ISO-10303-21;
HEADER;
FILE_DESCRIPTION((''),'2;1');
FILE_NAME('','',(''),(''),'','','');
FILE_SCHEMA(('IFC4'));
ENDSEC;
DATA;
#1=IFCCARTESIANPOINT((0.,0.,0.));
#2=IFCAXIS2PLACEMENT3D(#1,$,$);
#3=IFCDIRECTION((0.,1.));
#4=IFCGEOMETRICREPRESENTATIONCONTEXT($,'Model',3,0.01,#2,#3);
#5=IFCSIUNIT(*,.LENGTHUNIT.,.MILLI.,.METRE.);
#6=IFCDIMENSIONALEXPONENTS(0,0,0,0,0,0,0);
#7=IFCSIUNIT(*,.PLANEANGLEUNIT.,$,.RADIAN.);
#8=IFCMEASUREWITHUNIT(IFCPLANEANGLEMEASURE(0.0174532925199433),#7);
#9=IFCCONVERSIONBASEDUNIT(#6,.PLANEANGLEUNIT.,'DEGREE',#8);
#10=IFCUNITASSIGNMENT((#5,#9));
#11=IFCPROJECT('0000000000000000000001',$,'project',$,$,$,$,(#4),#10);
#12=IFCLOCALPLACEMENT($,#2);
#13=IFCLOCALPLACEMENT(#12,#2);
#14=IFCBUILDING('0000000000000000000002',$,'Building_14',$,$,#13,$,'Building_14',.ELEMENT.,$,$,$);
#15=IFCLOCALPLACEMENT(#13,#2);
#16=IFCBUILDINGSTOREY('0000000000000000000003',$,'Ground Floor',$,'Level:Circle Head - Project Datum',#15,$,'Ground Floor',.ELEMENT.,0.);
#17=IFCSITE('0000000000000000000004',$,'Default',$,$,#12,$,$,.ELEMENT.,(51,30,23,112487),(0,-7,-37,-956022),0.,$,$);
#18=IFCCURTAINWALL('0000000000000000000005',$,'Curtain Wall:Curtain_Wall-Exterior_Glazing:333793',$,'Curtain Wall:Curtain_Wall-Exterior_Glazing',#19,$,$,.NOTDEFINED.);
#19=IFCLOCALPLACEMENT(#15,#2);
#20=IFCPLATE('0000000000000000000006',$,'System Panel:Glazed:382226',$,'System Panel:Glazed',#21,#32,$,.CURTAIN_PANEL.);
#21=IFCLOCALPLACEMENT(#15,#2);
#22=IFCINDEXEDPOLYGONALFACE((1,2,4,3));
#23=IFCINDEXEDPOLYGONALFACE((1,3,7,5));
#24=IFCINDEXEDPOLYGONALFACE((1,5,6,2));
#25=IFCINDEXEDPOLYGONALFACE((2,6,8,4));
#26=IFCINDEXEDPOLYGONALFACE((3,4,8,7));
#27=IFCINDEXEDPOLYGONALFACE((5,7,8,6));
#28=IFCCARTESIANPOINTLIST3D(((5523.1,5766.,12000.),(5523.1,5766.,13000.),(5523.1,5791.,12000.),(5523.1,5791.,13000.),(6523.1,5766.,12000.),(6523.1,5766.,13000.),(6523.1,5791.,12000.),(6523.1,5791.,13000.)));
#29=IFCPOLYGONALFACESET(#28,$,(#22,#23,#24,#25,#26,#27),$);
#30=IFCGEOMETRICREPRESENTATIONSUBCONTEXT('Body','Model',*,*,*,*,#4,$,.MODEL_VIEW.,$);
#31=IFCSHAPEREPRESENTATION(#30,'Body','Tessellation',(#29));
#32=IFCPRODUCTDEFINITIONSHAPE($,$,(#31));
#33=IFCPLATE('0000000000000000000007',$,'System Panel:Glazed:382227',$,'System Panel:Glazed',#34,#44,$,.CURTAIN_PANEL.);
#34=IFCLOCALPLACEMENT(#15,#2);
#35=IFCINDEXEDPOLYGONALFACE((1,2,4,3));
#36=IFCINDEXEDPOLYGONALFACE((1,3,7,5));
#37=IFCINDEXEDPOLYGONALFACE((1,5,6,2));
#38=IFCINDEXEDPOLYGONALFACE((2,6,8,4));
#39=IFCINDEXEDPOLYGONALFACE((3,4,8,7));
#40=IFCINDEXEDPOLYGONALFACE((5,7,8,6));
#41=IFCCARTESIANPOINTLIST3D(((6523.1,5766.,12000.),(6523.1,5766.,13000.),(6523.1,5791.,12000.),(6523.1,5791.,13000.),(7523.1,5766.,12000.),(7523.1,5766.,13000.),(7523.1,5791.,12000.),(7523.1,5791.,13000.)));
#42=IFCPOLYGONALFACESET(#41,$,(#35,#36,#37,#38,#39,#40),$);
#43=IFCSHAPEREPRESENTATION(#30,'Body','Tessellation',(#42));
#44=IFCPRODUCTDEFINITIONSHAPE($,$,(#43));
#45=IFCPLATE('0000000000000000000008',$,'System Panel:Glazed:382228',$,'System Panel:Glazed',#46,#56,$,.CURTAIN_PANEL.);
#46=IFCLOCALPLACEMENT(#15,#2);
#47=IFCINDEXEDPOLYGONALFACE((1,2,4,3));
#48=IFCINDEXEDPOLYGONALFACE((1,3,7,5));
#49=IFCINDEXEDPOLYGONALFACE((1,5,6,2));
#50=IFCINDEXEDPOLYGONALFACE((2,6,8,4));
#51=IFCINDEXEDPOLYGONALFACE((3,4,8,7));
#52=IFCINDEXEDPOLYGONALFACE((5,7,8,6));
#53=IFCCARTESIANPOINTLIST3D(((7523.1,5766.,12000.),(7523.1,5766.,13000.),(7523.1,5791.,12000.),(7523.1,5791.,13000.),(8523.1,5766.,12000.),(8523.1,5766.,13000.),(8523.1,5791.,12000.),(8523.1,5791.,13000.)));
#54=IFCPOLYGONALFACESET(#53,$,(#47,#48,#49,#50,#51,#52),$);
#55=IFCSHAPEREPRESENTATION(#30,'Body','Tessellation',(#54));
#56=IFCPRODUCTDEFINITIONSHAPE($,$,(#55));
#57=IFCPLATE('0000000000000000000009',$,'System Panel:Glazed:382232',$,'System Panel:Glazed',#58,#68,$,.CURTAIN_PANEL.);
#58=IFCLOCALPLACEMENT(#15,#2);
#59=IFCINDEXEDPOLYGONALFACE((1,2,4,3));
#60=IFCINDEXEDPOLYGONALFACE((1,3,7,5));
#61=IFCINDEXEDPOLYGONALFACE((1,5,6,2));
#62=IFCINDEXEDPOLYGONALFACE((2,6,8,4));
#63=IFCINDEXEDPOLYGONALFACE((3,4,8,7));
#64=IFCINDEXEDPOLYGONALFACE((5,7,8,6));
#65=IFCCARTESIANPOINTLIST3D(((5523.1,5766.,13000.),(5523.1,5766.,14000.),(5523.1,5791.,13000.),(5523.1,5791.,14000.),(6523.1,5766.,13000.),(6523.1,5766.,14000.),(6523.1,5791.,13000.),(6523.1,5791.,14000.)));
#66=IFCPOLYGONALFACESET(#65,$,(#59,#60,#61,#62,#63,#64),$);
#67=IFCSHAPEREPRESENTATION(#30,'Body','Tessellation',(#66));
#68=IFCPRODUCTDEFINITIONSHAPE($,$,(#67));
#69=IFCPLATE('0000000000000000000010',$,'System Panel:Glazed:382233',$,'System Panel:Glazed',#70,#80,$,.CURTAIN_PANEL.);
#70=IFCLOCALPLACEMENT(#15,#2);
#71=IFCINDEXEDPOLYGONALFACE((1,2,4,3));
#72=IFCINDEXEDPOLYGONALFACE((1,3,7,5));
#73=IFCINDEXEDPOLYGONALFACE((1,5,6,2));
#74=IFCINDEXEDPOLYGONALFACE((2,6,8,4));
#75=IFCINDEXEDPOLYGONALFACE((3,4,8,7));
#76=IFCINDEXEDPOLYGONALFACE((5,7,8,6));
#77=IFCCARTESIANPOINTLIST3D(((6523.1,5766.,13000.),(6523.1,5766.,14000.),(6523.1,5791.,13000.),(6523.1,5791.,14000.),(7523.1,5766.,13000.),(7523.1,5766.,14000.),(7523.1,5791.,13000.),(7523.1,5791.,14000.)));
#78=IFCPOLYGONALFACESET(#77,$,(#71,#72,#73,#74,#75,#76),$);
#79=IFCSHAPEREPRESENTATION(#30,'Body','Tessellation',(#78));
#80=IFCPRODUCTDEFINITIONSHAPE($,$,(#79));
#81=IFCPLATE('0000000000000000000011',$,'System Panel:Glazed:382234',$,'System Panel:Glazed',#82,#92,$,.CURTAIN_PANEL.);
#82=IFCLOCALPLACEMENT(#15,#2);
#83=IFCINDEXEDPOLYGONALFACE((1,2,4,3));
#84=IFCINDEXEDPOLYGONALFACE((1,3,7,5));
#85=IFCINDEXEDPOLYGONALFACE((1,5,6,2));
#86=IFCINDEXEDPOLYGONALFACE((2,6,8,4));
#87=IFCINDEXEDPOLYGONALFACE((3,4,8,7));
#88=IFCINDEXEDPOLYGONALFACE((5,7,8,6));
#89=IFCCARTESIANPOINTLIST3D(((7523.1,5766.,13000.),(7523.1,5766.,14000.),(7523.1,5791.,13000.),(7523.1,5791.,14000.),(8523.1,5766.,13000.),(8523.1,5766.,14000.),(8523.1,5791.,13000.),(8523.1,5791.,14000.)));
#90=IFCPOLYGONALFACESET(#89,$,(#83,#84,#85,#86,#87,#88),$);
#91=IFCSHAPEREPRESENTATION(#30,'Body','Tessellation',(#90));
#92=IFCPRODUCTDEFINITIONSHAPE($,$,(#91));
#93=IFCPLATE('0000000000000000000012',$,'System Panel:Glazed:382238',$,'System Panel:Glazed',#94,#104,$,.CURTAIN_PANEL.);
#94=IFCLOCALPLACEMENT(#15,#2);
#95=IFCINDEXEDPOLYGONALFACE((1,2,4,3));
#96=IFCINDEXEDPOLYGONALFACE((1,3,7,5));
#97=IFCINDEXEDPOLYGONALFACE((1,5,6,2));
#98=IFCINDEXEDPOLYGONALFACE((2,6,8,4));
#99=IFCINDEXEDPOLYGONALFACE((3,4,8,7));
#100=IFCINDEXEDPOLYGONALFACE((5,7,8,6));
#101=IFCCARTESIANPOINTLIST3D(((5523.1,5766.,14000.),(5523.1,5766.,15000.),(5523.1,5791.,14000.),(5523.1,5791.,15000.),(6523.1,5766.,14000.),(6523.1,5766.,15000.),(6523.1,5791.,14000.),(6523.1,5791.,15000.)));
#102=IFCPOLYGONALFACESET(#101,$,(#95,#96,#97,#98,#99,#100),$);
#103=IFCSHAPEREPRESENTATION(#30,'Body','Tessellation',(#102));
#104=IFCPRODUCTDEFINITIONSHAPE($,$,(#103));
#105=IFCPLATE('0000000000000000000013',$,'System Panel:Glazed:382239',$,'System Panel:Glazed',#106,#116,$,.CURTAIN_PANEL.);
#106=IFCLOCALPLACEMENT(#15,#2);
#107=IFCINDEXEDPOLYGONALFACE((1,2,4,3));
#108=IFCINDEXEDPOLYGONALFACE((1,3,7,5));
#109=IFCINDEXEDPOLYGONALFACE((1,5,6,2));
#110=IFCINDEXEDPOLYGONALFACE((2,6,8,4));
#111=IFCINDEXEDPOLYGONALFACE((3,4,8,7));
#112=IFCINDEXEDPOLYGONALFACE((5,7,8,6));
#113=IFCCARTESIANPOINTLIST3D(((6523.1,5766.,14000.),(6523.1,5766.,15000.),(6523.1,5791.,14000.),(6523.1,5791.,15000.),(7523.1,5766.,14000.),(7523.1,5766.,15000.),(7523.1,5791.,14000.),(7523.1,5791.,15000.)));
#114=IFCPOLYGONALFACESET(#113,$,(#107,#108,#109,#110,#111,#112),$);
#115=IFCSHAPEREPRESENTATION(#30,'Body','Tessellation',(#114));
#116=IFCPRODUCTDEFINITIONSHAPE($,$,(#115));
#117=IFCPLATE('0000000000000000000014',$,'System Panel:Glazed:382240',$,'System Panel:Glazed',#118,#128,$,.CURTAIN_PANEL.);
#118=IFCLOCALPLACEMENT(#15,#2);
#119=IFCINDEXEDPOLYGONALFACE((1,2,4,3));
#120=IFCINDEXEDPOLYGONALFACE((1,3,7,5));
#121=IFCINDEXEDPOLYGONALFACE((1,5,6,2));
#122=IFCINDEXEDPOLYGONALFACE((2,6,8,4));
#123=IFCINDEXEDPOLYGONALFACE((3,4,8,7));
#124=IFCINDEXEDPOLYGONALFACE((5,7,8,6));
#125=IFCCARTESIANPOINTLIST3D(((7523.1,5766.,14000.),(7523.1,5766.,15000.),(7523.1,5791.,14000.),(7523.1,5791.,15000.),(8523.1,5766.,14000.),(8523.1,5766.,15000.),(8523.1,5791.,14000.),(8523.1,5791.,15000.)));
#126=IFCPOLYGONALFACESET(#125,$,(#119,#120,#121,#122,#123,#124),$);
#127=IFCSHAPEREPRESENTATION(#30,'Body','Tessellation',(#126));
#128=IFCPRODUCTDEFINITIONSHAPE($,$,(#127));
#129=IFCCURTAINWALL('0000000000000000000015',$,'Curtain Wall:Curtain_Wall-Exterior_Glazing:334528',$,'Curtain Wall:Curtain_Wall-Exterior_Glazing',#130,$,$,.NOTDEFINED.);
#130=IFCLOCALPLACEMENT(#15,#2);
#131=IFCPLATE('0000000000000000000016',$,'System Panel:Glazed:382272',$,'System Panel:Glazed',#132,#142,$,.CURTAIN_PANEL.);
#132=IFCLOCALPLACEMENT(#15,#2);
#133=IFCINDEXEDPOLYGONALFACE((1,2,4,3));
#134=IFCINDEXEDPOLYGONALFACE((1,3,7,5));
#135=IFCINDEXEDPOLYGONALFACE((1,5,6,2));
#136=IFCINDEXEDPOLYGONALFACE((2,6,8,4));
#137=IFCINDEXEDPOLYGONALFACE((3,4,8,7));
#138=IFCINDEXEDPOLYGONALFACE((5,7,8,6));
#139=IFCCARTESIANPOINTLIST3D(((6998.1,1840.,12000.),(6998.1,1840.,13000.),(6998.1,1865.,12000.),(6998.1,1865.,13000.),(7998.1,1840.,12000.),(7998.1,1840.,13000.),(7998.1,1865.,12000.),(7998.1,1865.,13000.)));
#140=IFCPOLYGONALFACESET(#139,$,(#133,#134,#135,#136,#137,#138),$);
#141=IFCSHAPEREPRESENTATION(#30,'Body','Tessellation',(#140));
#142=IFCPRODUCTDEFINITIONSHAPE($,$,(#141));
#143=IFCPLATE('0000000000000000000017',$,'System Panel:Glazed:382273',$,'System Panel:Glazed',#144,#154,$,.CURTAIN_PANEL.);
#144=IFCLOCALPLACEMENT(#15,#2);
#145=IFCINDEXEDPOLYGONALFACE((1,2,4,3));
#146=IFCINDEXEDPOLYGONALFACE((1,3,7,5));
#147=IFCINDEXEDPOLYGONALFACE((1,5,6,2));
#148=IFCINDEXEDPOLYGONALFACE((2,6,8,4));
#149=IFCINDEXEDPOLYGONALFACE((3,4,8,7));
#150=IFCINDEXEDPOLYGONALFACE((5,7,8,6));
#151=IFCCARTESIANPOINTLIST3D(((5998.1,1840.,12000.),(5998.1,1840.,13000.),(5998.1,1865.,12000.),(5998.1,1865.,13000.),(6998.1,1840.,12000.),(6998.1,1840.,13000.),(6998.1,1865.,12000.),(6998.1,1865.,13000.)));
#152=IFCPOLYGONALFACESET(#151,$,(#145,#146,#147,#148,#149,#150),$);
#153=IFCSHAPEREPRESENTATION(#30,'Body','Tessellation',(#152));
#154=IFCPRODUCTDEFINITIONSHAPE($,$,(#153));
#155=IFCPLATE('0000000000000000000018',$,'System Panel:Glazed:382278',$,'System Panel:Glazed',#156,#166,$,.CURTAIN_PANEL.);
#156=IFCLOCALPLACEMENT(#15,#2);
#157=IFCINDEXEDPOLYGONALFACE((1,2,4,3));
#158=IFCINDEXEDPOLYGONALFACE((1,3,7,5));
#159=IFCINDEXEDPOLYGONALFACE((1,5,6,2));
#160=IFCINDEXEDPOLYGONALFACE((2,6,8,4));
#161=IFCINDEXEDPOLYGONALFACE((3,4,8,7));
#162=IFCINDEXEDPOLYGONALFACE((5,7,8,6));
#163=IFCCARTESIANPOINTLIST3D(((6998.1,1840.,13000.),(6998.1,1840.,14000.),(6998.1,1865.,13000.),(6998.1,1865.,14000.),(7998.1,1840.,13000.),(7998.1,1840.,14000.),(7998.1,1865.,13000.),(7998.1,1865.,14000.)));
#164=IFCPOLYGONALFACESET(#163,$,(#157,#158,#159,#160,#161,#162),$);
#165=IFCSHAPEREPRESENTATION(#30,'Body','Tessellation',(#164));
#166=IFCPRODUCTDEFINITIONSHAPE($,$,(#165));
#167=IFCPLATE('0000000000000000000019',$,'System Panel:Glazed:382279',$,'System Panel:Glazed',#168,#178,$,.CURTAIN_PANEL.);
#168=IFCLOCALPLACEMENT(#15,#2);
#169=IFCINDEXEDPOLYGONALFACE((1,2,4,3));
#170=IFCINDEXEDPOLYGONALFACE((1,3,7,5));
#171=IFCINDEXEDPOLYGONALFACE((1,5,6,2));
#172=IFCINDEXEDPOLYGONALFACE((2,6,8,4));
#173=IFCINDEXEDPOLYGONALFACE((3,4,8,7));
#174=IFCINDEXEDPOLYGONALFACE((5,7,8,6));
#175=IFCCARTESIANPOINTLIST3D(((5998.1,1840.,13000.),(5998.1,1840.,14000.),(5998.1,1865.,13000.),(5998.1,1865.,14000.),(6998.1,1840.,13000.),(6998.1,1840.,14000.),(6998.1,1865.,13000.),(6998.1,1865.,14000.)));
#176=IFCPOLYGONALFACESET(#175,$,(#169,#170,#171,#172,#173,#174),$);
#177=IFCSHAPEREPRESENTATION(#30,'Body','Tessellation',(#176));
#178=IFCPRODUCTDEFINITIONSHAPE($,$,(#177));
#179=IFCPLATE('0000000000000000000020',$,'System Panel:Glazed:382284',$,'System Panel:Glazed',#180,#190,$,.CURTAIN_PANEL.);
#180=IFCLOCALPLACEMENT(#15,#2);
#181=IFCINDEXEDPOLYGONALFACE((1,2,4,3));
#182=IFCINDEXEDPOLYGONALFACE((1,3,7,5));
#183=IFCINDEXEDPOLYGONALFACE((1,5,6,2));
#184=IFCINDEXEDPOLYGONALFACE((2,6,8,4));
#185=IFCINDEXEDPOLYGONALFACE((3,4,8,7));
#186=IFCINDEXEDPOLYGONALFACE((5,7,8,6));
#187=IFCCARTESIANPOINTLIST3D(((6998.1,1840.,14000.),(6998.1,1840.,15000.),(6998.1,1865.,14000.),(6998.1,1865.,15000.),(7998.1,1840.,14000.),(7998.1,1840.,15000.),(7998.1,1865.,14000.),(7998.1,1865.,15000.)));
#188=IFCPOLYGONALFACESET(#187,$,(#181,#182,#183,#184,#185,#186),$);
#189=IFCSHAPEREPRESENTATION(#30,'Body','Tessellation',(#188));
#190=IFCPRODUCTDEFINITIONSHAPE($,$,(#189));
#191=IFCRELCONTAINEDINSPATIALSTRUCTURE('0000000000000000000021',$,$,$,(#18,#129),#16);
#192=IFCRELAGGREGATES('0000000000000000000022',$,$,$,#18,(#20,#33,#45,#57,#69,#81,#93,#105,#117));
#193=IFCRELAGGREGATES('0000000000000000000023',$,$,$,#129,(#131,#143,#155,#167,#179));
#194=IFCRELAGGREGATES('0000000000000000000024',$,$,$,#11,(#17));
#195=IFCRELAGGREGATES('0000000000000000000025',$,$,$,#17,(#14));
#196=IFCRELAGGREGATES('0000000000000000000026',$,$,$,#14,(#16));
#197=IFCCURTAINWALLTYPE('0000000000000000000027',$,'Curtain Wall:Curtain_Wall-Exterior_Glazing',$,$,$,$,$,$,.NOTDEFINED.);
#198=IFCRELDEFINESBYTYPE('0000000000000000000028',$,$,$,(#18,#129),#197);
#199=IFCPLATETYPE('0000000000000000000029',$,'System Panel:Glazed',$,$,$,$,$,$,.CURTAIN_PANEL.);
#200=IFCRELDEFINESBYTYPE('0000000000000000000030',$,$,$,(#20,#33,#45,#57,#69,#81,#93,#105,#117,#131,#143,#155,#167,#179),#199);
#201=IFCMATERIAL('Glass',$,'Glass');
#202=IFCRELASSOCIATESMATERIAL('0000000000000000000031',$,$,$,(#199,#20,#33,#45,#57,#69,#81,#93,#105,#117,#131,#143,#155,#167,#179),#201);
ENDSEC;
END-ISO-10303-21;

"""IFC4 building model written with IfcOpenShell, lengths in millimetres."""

from ifc_helpers import new_model, entity, si_unit, converted_unit, direction, frame, origin, place, context, subcontext, project, spatial, indexed_curve, outline, extrude, source, transform, mapped, material, type_object, type_shapes, element, aggregate, save


model = new_model("IFC4")

# Units and contexts
model_context = context("Model", 3, precision=0.01, world=origin(), true_north=direction((0.0, 1.0)))
body_context = subcontext(model_context, "Body", "Model", "MODEL_VIEW")
ifc_project = project(units=[si_unit("LENGTHUNIT", "METRE", prefix="MILLI"), converted_unit("PLANEANGLEUNIT", "DEGREE", entity("IfcPlaneAngleMeasure", 0.0174532925199433), si_unit("PLANEANGLEUNIT", "RADIAN"), dimensions=[0, 0, 0, 0, 0, 0, 0])], contexts=[model_context])

# Site, building, storey
site_placement = place(None, origin())
site = spatial("IfcSite", under=ifc_project, at=site_placement, Name="Default", CompositionType="ELEMENT", RefLatitude=(51, 30, 23, 112487), RefLongitude=(0, -7, -37, -956022), RefElevation=0.0)
building_placement = place(site_placement, origin())
building = spatial("IfcBuilding", under=site, at=building_placement, Name="Building_14", LongName="Building_14", CompositionType="ELEMENT")
storey_placement = place(building_placement, origin())
storey = spatial("IfcBuildingStorey", under=building, at=storey_placement, Name="Ground Floor", ObjectType="Level:Circle Head - Project Datum", LongName="Ground Floor", CompositionType="ELEMENT", Elevation=0.0)

# Curtain walls, plates
curtain_wall_type = type_object("IfcCurtainWallType", Name="Curtain Wall:Curtain_Wall-Exterior_Glazing", PredefinedType="NOTDEFINED")
curtain_wall_1_placement = place(storey_placement, origin())
curtain_wall_1 = element("IfcCurtainWall", 1, at=curtain_wall_1_placement, inside=storey, type_object=curtain_wall_type, Name="Curtain Wall:Curtain_Wall-Exterior_Glazing:333793", ObjectType="Curtain Wall:Curtain_Wall-Exterior_Glazing", PredefinedType="NOTDEFINED")
ifc_material = material(Name="Glass", Category="Glass")
plate_type_1 = type_object("IfcPlateType", Name="System Panel:Glazed", PredefinedType="CURTAIN_PANEL", material=ifc_material)
shared_shape_1 = source(origin(), body_context, "Body", "SweptSolid", [
    extrude(outline(indexed_curve([(-12.5, -500.0), (12.5, -500.0), (12.5, 500.0), (-12.5, 500.0), (-12.5, -500.0)], self_intersect=False)), frame((0.0, -37.0, 0.0), z_axis=(0.0, 0.0, 1.0), x_axis=(0.0, 1.0, 0.0)), (0.0, 0.0, 1.0), 1000.0),
])
type_shapes(plate_type_1, [shared_shape_1])
plate_1_placement = place(curtain_wall_1_placement, frame((6023.1, 5815.5, 12000.0)))
plate_1 = element("IfcPlate", 2, at=plate_1_placement, type_object=plate_type_1, material=ifc_material, Name="System Panel:Glazed:382226", ObjectType="System Panel:Glazed", PredefinedType="CURTAIN_PANEL", context=body_context, shape_type="MappedRepresentation", body=[
    mapped(shared_shape_1, transform((0.0, 0.0, 0.0), scale=1.0)),
])
plate_2_placement = place(curtain_wall_1_placement, frame((7023.1, 5815.5, 12000.0)))
plate_2 = element("IfcPlate", 3, at=plate_2_placement, type_object=plate_type_1, material=ifc_material, Name="System Panel:Glazed:382227", ObjectType="System Panel:Glazed", PredefinedType="CURTAIN_PANEL", context=body_context, shape_type="MappedRepresentation", body=[
    mapped(shared_shape_1, transform((0.0, 0.0, 0.0), scale=1.0)),
])
plate_3_placement = place(curtain_wall_1_placement, frame((8023.1, 5815.5, 12000.0)))
plate_3 = element("IfcPlate", 4, at=plate_3_placement, type_object=plate_type_1, material=ifc_material, Name="System Panel:Glazed:382228", ObjectType="System Panel:Glazed", PredefinedType="CURTAIN_PANEL", context=body_context, shape_type="MappedRepresentation", body=[
    mapped(shared_shape_1, transform((0.0, 0.0, 0.0), scale=1.0)),
])
plate_4_placement = place(curtain_wall_1_placement, frame((6023.1, 5815.5, 13000.0)))
plate_4 = element("IfcPlate", 5, at=plate_4_placement, type_object=plate_type_1, material=ifc_material, Name="System Panel:Glazed:382232", ObjectType="System Panel:Glazed", PredefinedType="CURTAIN_PANEL", context=body_context, shape_type="MappedRepresentation", body=[
    mapped(shared_shape_1, transform((0.0, 0.0, 0.0), scale=1.0)),
])
plate_5_placement = place(curtain_wall_1_placement, frame((7023.1, 5815.5, 13000.0)))
plate_5 = element("IfcPlate", 6, at=plate_5_placement, type_object=plate_type_1, material=ifc_material, Name="System Panel:Glazed:382233", ObjectType="System Panel:Glazed", PredefinedType="CURTAIN_PANEL", context=body_context, shape_type="MappedRepresentation", body=[
    mapped(shared_shape_1, transform((0.0, 0.0, 0.0), scale=1.0)),
])
plate_6_placement = place(curtain_wall_1_placement, frame((8023.1, 5815.5, 13000.0)))
plate_6 = element("IfcPlate", 7, at=plate_6_placement, type_object=plate_type_1, material=ifc_material, Name="System Panel:Glazed:382234", ObjectType="System Panel:Glazed", PredefinedType="CURTAIN_PANEL", context=body_context, shape_type="MappedRepresentation", body=[
    mapped(shared_shape_1, transform((0.0, 0.0, 0.0), scale=1.0)),
])
plate_7_placement = place(curtain_wall_1_placement, frame((6023.1, 5815.5, 14000.0)))
plate_7 = element("IfcPlate", 8, at=plate_7_placement, type_object=plate_type_1, material=ifc_material, Name="System Panel:Glazed:382238", ObjectType="System Panel:Glazed", PredefinedType="CURTAIN_PANEL", context=body_context, shape_type="MappedRepresentation", body=[
    mapped(shared_shape_1, transform((0.0, 0.0, 0.0), scale=1.0)),
])
plate_8_placement = place(curtain_wall_1_placement, frame((7023.1, 5815.5, 14000.0)))
plate_8 = element("IfcPlate", 9, at=plate_8_placement, type_object=plate_type_1, material=ifc_material, Name="System Panel:Glazed:382239", ObjectType="System Panel:Glazed", PredefinedType="CURTAIN_PANEL", context=body_context, shape_type="MappedRepresentation", body=[
    mapped(shared_shape_1, transform((0.0, 0.0, 0.0), scale=1.0)),
])
plate_9_placement = place(curtain_wall_1_placement, frame((8023.1, 5815.5, 14000.0)))
plate_9 = element("IfcPlate", 10, at=plate_9_placement, type_object=plate_type_1, material=ifc_material, Name="System Panel:Glazed:382240", ObjectType="System Panel:Glazed", PredefinedType="CURTAIN_PANEL", context=body_context, shape_type="MappedRepresentation", body=[
    mapped(shared_shape_1, transform((0.0, 0.0, 0.0), scale=1.0)),
])
curtain_wall_2_placement = place(storey_placement, origin())
curtain_wall_2 = element("IfcCurtainWall", 11, at=curtain_wall_2_placement, inside=storey, type_object=curtain_wall_type, Name="Curtain Wall:Curtain_Wall-Exterior_Glazing:334528", ObjectType="Curtain Wall:Curtain_Wall-Exterior_Glazing", PredefinedType="NOTDEFINED")
plate_10_placement = place(curtain_wall_2_placement, frame((7498.1, 1815.5, 12000.0), z_axis=(0.0, 0.0, 1.0), x_axis=(-1.0, 0.0, 0.0)))
plate_10 = element("IfcPlate", 12, at=plate_10_placement, type_object=plate_type_1, material=ifc_material, Name="System Panel:Glazed:382272", ObjectType="System Panel:Glazed", PredefinedType="CURTAIN_PANEL", context=body_context, shape_type="MappedRepresentation", body=[
    mapped(shared_shape_1, transform((0.0, 0.0, 0.0), scale=1.0)),
])
plate_11_placement = place(curtain_wall_2_placement, frame((6498.1, 1815.5, 12000.0), z_axis=(0.0, 0.0, 1.0), x_axis=(-1.0, 0.0, 0.0)))
plate_11 = element("IfcPlate", 13, at=plate_11_placement, type_object=plate_type_1, material=ifc_material, Name="System Panel:Glazed:382273", ObjectType="System Panel:Glazed", PredefinedType="CURTAIN_PANEL", context=body_context, shape_type="MappedRepresentation", body=[
    mapped(shared_shape_1, transform((0.0, 0.0, 0.0), scale=1.0)),
])
plate_12_placement = place(curtain_wall_2_placement, frame((7498.1, 1815.5, 13000.0), z_axis=(0.0, 0.0, 1.0), x_axis=(-1.0, 0.0, 0.0)))
plate_12 = element("IfcPlate", 14, at=plate_12_placement, type_object=plate_type_1, material=ifc_material, Name="System Panel:Glazed:382278", ObjectType="System Panel:Glazed", PredefinedType="CURTAIN_PANEL", context=body_context, shape_type="MappedRepresentation", body=[
    mapped(shared_shape_1, transform((0.0, 0.0, 0.0), scale=1.0)),
])
plate_13_placement = place(curtain_wall_2_placement, frame((6498.1, 1815.5, 13000.0), z_axis=(0.0, 0.0, 1.0), x_axis=(-1.0, 0.0, 0.0)))
plate_13 = element("IfcPlate", 15, at=plate_13_placement, type_object=plate_type_1, material=ifc_material, Name="System Panel:Glazed:382279", ObjectType="System Panel:Glazed", PredefinedType="CURTAIN_PANEL", context=body_context, shape_type="MappedRepresentation", body=[
    mapped(shared_shape_1, transform((0.0, 0.0, 0.0), scale=1.0)),
])
plate_14_placement = place(curtain_wall_2_placement, frame((7498.1, 1815.5, 14000.0), z_axis=(0.0, 0.0, 1.0), x_axis=(-1.0, 0.0, 0.0)))
plate_14 = element("IfcPlate", 16, at=plate_14_placement, type_object=plate_type_1, material=ifc_material, Name="System Panel:Glazed:382284", ObjectType="System Panel:Glazed", PredefinedType="CURTAIN_PANEL", context=body_context, shape_type="MappedRepresentation", body=[
    mapped(shared_shape_1, transform((0.0, 0.0, 0.0), scale=1.0)),
])

aggregate(curtain_wall_1, [plate_1, plate_2, plate_3, plate_4, plate_5, plate_6, plate_7, plate_8, plate_9])
aggregate(curtain_wall_2, [plate_10, plate_11, plate_12, plate_13, plate_14])

save(model, "model.ifc")
